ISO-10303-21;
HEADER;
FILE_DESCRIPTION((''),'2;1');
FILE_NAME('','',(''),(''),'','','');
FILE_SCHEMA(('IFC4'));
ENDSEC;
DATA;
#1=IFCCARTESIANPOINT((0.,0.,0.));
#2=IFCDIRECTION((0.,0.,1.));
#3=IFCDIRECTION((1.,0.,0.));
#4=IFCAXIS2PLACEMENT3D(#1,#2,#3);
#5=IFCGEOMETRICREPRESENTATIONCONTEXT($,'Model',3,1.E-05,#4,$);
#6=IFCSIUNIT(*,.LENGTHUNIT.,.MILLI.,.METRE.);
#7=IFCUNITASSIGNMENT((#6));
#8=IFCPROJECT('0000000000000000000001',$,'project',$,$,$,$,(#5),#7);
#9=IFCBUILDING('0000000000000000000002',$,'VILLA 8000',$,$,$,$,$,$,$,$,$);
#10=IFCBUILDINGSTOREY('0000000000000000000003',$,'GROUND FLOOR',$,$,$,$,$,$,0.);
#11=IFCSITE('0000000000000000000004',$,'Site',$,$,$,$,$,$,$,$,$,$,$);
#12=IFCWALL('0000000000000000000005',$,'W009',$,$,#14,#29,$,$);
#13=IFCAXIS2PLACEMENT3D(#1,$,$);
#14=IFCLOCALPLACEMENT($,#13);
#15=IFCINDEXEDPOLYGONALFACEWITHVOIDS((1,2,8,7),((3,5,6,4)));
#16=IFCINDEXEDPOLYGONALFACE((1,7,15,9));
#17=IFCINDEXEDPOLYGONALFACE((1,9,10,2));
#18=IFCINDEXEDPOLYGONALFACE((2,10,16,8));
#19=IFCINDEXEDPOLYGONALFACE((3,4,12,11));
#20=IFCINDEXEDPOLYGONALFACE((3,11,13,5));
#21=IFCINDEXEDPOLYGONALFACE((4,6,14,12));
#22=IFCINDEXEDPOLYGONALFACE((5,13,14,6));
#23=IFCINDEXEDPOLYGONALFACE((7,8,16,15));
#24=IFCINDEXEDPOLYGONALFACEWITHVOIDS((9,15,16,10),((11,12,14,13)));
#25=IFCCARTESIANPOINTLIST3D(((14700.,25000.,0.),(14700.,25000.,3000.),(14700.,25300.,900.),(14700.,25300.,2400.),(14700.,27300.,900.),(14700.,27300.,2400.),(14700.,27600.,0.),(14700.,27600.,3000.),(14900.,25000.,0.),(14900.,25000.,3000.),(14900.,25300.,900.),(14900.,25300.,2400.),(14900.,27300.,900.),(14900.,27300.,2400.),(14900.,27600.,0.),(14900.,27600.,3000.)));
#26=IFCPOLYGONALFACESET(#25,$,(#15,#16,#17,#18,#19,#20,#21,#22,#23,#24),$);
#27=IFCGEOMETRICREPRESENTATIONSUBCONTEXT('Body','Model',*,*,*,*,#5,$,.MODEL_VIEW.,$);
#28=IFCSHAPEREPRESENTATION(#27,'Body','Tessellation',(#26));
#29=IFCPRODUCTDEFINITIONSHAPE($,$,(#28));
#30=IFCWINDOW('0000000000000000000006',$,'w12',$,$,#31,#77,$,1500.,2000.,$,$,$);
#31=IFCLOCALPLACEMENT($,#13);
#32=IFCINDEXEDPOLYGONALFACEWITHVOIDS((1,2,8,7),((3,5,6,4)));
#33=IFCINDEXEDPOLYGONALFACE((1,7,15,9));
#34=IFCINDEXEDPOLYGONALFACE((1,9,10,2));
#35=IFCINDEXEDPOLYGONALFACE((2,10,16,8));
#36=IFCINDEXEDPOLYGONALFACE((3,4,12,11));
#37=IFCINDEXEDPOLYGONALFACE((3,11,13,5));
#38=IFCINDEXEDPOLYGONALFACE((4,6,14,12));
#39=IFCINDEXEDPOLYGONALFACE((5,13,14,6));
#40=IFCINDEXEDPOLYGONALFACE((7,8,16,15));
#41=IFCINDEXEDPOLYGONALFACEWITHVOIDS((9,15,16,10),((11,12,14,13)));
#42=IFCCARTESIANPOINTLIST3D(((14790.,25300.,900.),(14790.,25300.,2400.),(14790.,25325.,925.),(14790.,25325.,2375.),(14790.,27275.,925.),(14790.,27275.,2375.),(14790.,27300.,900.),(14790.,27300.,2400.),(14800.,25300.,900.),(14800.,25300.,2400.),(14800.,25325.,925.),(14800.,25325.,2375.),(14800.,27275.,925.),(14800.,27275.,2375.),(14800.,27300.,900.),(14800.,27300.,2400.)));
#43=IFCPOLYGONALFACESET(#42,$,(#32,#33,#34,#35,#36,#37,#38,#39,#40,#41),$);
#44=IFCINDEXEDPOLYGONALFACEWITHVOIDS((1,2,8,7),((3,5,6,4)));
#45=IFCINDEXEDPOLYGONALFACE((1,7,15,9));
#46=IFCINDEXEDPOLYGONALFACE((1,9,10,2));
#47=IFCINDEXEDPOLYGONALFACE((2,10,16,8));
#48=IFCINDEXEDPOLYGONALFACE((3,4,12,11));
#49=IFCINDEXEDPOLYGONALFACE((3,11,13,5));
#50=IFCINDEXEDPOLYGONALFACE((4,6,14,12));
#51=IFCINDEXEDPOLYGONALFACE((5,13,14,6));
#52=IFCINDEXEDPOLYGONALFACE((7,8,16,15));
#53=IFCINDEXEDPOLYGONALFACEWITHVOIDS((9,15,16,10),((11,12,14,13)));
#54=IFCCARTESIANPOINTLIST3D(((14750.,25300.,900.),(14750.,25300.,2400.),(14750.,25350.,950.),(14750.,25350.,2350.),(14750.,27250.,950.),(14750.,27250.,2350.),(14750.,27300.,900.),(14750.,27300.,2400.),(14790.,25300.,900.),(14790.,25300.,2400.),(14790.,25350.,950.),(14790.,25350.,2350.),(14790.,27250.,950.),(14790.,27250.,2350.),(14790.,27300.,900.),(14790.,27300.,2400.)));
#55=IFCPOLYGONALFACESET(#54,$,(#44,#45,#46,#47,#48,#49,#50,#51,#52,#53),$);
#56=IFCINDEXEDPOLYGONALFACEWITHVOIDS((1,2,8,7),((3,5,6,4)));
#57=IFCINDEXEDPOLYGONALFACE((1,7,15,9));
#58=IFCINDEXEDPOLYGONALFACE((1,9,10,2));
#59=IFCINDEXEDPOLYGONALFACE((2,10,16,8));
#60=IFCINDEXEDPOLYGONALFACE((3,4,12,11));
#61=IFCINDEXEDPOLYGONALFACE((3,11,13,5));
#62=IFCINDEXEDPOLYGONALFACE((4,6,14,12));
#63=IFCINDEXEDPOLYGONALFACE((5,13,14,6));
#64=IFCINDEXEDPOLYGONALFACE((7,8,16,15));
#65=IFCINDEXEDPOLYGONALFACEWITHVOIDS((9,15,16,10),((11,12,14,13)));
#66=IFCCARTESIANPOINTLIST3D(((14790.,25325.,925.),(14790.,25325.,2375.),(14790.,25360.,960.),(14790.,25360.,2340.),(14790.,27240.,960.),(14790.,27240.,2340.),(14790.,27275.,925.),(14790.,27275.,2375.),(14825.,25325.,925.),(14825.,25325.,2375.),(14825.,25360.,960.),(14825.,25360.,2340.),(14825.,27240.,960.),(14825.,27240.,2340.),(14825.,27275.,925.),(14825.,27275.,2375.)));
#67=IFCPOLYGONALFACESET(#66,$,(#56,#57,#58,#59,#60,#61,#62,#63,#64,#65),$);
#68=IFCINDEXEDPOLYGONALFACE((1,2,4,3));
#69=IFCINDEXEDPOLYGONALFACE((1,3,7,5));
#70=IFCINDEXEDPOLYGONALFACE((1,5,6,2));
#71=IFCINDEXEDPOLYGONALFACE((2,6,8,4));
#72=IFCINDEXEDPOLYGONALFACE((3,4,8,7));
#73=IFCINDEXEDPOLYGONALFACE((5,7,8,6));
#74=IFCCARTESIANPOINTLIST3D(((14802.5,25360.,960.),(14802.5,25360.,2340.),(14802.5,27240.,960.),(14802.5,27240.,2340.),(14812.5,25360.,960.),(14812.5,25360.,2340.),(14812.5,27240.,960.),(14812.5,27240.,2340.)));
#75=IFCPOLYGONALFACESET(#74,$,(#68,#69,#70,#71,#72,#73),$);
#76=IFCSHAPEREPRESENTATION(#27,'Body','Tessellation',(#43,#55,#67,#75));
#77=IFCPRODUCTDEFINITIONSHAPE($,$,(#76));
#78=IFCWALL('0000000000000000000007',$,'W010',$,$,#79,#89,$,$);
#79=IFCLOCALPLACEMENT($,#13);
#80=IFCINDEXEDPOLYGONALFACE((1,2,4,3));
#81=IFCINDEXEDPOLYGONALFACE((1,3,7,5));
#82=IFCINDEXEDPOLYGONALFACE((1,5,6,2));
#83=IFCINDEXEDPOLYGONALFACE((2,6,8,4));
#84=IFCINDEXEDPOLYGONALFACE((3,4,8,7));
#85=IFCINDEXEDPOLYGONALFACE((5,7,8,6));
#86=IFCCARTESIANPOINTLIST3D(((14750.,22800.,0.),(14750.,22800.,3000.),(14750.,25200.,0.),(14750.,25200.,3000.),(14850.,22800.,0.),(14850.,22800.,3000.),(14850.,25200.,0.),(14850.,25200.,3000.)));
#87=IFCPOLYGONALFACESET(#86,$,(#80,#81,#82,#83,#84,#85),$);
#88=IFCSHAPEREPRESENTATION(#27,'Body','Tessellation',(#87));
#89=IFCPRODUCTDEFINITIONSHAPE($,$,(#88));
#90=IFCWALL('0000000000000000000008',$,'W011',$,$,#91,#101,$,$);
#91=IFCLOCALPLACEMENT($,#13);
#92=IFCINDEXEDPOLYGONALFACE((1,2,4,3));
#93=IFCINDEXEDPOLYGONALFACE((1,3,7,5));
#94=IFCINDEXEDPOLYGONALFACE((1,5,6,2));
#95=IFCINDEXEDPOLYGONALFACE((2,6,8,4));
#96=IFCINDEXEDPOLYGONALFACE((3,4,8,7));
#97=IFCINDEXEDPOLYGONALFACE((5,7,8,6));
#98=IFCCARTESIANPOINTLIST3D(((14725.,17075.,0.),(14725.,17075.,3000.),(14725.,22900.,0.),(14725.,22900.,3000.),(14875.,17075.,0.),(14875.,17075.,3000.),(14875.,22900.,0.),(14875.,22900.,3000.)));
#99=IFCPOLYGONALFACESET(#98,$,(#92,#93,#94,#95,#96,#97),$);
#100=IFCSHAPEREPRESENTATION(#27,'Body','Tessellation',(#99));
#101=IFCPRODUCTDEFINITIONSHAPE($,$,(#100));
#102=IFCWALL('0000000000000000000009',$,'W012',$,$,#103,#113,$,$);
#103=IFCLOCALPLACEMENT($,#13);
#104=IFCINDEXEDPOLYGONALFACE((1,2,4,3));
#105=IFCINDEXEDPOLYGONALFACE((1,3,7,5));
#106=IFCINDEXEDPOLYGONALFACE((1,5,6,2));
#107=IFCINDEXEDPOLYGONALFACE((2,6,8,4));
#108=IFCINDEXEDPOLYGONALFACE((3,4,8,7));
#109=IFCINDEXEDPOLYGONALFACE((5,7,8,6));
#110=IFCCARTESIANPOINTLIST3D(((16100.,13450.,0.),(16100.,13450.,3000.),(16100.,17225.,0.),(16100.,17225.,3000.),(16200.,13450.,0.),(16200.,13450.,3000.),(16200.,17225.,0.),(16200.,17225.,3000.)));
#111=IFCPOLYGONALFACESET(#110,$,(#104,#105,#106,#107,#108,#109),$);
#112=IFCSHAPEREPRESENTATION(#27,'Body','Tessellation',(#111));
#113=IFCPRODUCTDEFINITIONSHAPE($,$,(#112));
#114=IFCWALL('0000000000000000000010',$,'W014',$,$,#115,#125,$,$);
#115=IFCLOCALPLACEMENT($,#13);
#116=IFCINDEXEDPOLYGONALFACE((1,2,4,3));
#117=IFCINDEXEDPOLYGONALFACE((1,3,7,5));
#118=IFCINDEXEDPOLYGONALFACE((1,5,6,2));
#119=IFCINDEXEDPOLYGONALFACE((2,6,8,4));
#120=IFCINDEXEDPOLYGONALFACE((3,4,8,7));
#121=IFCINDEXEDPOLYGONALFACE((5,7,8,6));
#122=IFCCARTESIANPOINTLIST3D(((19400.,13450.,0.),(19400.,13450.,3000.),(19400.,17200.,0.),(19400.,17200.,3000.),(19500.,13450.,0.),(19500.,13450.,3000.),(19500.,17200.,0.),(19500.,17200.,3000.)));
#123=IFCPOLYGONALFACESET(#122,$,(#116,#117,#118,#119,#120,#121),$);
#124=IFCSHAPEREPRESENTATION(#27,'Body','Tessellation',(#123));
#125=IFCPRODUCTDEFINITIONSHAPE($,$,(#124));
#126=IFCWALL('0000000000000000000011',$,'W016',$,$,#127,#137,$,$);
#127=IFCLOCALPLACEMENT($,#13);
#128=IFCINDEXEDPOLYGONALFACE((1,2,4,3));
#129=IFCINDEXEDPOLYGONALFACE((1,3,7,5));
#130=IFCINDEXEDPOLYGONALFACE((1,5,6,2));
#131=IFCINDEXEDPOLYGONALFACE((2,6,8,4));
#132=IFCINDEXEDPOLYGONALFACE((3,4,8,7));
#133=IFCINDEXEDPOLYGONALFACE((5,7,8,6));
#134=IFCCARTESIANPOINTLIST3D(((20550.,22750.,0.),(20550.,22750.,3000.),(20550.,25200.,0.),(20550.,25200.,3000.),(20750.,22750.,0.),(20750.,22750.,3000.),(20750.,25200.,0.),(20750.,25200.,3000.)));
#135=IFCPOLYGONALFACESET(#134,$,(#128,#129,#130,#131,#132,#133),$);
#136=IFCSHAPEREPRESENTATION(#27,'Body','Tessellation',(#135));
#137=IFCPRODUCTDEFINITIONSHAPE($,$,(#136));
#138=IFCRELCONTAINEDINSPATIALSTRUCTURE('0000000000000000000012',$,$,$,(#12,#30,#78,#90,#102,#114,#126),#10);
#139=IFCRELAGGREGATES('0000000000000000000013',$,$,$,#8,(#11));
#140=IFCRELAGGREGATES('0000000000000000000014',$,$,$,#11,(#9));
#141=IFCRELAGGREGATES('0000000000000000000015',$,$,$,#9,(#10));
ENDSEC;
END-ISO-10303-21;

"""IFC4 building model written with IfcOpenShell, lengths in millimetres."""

from ifc_helpers import new_model, si_unit, frame, origin_with_axes, place, context, subcontext, project, spatial, line, indexed_curve, outline, extrude, element, fill, save


model = new_model("IFC4")

# Units and contexts
model_context = context("Model", 3, precision=1e-05, world=origin_with_axes())
body_context = subcontext(model_context, "Body", "Model", "MODEL_VIEW")
ifc_project = project(units=[si_unit("LENGTHUNIT", "METRE", prefix="MILLI")], contexts=[model_context])

# Site, building, storey
site = spatial("IfcSite", under=ifc_project, Name="Site")
building = spatial("IfcBuilding", under=site, Name="VILLA 8000")
storey = spatial("IfcBuildingStorey", under=building, Name="GROUND FLOOR", Elevation=0.0)

# Wall, opening, window
wall_1_placement = place(None, frame((14800.0, 27600.0, 0.0), z_axis=(0.0, 0.0, 1.0), x_axis=(0.0, -1.0, 0.0)))
wall_1 = element("IfcWall", 1, at=wall_1_placement, inside=storey, Name="W009", context=body_context, shape_type="SweptSolid", body=[
    extrude(outline(indexed_curve([(0.0, 0.0), (0.0, 200.0), (2600.0, 200.0), (2600.0, 0.0), (0.0, 0.0)], self_intersect=False)), frame((0.0, -100.0, 0.0), z_axis=(0.0, 0.0, 1.0), x_axis=(1.0, 0.0, 0.0)), (0.0, 0.0, 1.0), 3000.0),
])
opening_1_placement = place(wall_1_placement, frame((300.0, 0.0, 900.0), z_axis=(0.0, 0.0, 1.0), x_axis=(1.0, 0.0, 0.0)))
opening_1 = element("IfcOpeningElement", 2, at=opening_1_placement, cuts=wall_1, context=body_context, shape_type="SweptSolid", body=[
    extrude(outline(indexed_curve([(0.0, 0.0), (0.0, 300.0), (2000.0, 300.0), (2000.0, 0.0), (0.0, 0.0)], self_intersect=False)), frame((0.0, -150.0, 0.0), z_axis=(0.0, 0.0, 1.0), x_axis=(1.0, 0.0, 0.0)), (0.0, 0.0, 1.0), 1500.0),
])
window_1_placement = place(None, frame((14700.0, 27300.0, 900.0), z_axis=(0.0, 0.0, 1.0), x_axis=(0.0, -1.0, 0.0)))
window_1 = element("IfcWindow", 3, at=window_1_placement, inside=storey, Name="w12", OverallHeight=1500.0, OverallWidth=2000.0, context=body_context, shape_type="SweptSolid", body=[
    extrude(outline(indexed_curve([(0.0, 0.0), (2000.0, 0.0), (2000.0, 1500.0), (0.0, 1500.0)], segments=[line(1, 2, 3, 4, 1)]), holes=[indexed_curve([(25.0, 25.0), (1975.0, 25.0), (1975.0, 1475.0), (25.0, 1475.0)], segments=[line(1, 2, 3, 4, 1)])]), frame((0.0, 90.0, 0.0), z_axis=(0.0, -1.0, 0.0), x_axis=(1.0, 0.0, 0.0)), (0.0, 0.0, -1.0), 10.0),
    extrude(outline(indexed_curve([(0.0, 0.0), (2000.0, 0.0), (2000.0, 1500.0), (0.0, 1500.0)], segments=[line(1, 2, 3, 4, 1)]), holes=[indexed_curve([(50.0, 50.0), (1950.0, 50.0), (1950.0, 1450.0), (50.0, 1450.0)], segments=[line(1, 2, 3, 4, 1)])]), frame((0.0, 50.0, 0.0), z_axis=(0.0, -1.0, 0.0), x_axis=(1.0, 0.0, 0.0)), (0.0, 0.0, -1.0), 40.0),
    extrude(outline(indexed_curve([(0.0, 0.0), (1950.0, 0.0), (1950.0, 1450.0), (0.0, 1450.0)], segments=[line(1, 2, 3, 4, 1)]), holes=[indexed_curve([(35.0, 35.0), (1915.0, 35.0), (1915.0, 1415.0), (35.0, 1415.0)], segments=[line(1, 2, 3, 4, 1)])]), frame((25.0, 90.0, 25.0), z_axis=(0.0, -1.0, 0.0), x_axis=(1.0, 0.0, 0.0)), (0.0, 0.0, -1.0), 35.0),
    extrude(outline(indexed_curve([(35.0, 35.0), (1915.0, 35.0), (1915.0, 1415.0), (35.0, 1415.0)], segments=[line(1, 2, 3, 4, 1)])), frame((25.0, 102.5, 25.0), z_axis=(0.0, -1.0, 0.0), x_axis=(1.0, 0.0, 0.0)), (0.0, 0.0, -1.0), 10.0),
])
fill(opening_1, window_1)

# Walls
wall_2_placement = place(None, frame((14800.0, 25200.0, 0.0), z_axis=(0.0, 0.0, 1.0), x_axis=(0.0, -1.0, 0.0)))
element("IfcWall", 4, at=wall_2_placement, inside=storey, Name="W010", context=body_context, shape_type="SweptSolid", body=[
    extrude(outline(indexed_curve([(0.0, 0.0), (0.0, 100.0), (2400.0, 100.0), (2400.0, 0.0), (0.0, 0.0)], self_intersect=False)), frame((0.0, -50.0, 0.0), z_axis=(0.0, 0.0, 1.0), x_axis=(1.0, 0.0, 0.0)), (0.0, 0.0, 1.0), 3000.0),
])
wall_3_placement = place(None, frame((14800.0, 22900.0, 0.0), z_axis=(0.0, 0.0, 1.0), x_axis=(0.0, -1.0, 0.0)))
element("IfcWall", 5, at=wall_3_placement, inside=storey, Name="W011", context=body_context, shape_type="SweptSolid", body=[
    extrude(outline(indexed_curve([(0.0, 0.0), (0.0, 150.0), (5825.0, 150.0), (5825.0, 0.0), (0.0, 0.0)], self_intersect=False)), frame((0.0, -75.0, 0.0), z_axis=(0.0, 0.0, 1.0), x_axis=(1.0, 0.0, 0.0)), (0.0, 0.0, 1.0), 3000.0),
])
wall_4_placement = place(None, frame((16150.0, 17225.0, 0.0), z_axis=(0.0, 0.0, 1.0), x_axis=(0.0, -1.0, 0.0)))
element("IfcWall", 6, at=wall_4_placement, inside=storey, Name="W012", context=body_context, shape_type="SweptSolid", body=[
    extrude(outline(indexed_curve([(0.0, 0.0), (0.0, 100.0), (3775.0, 100.0), (3775.0, 0.0), (0.0, 0.0)], self_intersect=False)), frame((0.0, -50.0, 0.0), z_axis=(0.0, 0.0, 1.0), x_axis=(1.0, 0.0, 0.0)), (0.0, 0.0, 1.0), 3000.0),
])

# Walls
wall_5_placement = place(None, frame((19450.0, 17200.0, 0.0), z_axis=(0.0, 0.0, 1.0), x_axis=(0.0, -1.0, 0.0)))
element("IfcWall", 7, at=wall_5_placement, inside=storey, Name="W014", context=body_context, shape_type="SweptSolid", body=[
    extrude(outline(indexed_curve([(0.0, 0.0), (0.0, 100.0), (3750.0, 100.0), (3750.0, 0.0), (0.0, 0.0)], self_intersect=False)), frame((0.0, -50.0, 0.0), z_axis=(0.0, 0.0, 1.0), x_axis=(1.0, 0.0, 0.0)), (0.0, 0.0, 1.0), 3000.0),
])
wall_6_placement = place(None, frame((20650.0, 25200.0, 0.0), z_axis=(0.0, 0.0, 1.0), x_axis=(0.0, -1.0, 0.0)))
element("IfcWall", 8, at=wall_6_placement, inside=storey, Name="W016", context=body_context, shape_type="SweptSolid", body=[
    extrude(outline(indexed_curve([(0.0, 0.0), (0.0, 200.0), (2450.0, 200.0), (2450.0, 0.0), (0.0, 0.0)], self_intersect=False)), frame((0.0, -100.0, 0.0), z_axis=(0.0, 0.0, 1.0), x_axis=(1.0, 0.0, 0.0)), (0.0, 0.0, 1.0), 3000.0),
])

save(model, "model.ifc")
